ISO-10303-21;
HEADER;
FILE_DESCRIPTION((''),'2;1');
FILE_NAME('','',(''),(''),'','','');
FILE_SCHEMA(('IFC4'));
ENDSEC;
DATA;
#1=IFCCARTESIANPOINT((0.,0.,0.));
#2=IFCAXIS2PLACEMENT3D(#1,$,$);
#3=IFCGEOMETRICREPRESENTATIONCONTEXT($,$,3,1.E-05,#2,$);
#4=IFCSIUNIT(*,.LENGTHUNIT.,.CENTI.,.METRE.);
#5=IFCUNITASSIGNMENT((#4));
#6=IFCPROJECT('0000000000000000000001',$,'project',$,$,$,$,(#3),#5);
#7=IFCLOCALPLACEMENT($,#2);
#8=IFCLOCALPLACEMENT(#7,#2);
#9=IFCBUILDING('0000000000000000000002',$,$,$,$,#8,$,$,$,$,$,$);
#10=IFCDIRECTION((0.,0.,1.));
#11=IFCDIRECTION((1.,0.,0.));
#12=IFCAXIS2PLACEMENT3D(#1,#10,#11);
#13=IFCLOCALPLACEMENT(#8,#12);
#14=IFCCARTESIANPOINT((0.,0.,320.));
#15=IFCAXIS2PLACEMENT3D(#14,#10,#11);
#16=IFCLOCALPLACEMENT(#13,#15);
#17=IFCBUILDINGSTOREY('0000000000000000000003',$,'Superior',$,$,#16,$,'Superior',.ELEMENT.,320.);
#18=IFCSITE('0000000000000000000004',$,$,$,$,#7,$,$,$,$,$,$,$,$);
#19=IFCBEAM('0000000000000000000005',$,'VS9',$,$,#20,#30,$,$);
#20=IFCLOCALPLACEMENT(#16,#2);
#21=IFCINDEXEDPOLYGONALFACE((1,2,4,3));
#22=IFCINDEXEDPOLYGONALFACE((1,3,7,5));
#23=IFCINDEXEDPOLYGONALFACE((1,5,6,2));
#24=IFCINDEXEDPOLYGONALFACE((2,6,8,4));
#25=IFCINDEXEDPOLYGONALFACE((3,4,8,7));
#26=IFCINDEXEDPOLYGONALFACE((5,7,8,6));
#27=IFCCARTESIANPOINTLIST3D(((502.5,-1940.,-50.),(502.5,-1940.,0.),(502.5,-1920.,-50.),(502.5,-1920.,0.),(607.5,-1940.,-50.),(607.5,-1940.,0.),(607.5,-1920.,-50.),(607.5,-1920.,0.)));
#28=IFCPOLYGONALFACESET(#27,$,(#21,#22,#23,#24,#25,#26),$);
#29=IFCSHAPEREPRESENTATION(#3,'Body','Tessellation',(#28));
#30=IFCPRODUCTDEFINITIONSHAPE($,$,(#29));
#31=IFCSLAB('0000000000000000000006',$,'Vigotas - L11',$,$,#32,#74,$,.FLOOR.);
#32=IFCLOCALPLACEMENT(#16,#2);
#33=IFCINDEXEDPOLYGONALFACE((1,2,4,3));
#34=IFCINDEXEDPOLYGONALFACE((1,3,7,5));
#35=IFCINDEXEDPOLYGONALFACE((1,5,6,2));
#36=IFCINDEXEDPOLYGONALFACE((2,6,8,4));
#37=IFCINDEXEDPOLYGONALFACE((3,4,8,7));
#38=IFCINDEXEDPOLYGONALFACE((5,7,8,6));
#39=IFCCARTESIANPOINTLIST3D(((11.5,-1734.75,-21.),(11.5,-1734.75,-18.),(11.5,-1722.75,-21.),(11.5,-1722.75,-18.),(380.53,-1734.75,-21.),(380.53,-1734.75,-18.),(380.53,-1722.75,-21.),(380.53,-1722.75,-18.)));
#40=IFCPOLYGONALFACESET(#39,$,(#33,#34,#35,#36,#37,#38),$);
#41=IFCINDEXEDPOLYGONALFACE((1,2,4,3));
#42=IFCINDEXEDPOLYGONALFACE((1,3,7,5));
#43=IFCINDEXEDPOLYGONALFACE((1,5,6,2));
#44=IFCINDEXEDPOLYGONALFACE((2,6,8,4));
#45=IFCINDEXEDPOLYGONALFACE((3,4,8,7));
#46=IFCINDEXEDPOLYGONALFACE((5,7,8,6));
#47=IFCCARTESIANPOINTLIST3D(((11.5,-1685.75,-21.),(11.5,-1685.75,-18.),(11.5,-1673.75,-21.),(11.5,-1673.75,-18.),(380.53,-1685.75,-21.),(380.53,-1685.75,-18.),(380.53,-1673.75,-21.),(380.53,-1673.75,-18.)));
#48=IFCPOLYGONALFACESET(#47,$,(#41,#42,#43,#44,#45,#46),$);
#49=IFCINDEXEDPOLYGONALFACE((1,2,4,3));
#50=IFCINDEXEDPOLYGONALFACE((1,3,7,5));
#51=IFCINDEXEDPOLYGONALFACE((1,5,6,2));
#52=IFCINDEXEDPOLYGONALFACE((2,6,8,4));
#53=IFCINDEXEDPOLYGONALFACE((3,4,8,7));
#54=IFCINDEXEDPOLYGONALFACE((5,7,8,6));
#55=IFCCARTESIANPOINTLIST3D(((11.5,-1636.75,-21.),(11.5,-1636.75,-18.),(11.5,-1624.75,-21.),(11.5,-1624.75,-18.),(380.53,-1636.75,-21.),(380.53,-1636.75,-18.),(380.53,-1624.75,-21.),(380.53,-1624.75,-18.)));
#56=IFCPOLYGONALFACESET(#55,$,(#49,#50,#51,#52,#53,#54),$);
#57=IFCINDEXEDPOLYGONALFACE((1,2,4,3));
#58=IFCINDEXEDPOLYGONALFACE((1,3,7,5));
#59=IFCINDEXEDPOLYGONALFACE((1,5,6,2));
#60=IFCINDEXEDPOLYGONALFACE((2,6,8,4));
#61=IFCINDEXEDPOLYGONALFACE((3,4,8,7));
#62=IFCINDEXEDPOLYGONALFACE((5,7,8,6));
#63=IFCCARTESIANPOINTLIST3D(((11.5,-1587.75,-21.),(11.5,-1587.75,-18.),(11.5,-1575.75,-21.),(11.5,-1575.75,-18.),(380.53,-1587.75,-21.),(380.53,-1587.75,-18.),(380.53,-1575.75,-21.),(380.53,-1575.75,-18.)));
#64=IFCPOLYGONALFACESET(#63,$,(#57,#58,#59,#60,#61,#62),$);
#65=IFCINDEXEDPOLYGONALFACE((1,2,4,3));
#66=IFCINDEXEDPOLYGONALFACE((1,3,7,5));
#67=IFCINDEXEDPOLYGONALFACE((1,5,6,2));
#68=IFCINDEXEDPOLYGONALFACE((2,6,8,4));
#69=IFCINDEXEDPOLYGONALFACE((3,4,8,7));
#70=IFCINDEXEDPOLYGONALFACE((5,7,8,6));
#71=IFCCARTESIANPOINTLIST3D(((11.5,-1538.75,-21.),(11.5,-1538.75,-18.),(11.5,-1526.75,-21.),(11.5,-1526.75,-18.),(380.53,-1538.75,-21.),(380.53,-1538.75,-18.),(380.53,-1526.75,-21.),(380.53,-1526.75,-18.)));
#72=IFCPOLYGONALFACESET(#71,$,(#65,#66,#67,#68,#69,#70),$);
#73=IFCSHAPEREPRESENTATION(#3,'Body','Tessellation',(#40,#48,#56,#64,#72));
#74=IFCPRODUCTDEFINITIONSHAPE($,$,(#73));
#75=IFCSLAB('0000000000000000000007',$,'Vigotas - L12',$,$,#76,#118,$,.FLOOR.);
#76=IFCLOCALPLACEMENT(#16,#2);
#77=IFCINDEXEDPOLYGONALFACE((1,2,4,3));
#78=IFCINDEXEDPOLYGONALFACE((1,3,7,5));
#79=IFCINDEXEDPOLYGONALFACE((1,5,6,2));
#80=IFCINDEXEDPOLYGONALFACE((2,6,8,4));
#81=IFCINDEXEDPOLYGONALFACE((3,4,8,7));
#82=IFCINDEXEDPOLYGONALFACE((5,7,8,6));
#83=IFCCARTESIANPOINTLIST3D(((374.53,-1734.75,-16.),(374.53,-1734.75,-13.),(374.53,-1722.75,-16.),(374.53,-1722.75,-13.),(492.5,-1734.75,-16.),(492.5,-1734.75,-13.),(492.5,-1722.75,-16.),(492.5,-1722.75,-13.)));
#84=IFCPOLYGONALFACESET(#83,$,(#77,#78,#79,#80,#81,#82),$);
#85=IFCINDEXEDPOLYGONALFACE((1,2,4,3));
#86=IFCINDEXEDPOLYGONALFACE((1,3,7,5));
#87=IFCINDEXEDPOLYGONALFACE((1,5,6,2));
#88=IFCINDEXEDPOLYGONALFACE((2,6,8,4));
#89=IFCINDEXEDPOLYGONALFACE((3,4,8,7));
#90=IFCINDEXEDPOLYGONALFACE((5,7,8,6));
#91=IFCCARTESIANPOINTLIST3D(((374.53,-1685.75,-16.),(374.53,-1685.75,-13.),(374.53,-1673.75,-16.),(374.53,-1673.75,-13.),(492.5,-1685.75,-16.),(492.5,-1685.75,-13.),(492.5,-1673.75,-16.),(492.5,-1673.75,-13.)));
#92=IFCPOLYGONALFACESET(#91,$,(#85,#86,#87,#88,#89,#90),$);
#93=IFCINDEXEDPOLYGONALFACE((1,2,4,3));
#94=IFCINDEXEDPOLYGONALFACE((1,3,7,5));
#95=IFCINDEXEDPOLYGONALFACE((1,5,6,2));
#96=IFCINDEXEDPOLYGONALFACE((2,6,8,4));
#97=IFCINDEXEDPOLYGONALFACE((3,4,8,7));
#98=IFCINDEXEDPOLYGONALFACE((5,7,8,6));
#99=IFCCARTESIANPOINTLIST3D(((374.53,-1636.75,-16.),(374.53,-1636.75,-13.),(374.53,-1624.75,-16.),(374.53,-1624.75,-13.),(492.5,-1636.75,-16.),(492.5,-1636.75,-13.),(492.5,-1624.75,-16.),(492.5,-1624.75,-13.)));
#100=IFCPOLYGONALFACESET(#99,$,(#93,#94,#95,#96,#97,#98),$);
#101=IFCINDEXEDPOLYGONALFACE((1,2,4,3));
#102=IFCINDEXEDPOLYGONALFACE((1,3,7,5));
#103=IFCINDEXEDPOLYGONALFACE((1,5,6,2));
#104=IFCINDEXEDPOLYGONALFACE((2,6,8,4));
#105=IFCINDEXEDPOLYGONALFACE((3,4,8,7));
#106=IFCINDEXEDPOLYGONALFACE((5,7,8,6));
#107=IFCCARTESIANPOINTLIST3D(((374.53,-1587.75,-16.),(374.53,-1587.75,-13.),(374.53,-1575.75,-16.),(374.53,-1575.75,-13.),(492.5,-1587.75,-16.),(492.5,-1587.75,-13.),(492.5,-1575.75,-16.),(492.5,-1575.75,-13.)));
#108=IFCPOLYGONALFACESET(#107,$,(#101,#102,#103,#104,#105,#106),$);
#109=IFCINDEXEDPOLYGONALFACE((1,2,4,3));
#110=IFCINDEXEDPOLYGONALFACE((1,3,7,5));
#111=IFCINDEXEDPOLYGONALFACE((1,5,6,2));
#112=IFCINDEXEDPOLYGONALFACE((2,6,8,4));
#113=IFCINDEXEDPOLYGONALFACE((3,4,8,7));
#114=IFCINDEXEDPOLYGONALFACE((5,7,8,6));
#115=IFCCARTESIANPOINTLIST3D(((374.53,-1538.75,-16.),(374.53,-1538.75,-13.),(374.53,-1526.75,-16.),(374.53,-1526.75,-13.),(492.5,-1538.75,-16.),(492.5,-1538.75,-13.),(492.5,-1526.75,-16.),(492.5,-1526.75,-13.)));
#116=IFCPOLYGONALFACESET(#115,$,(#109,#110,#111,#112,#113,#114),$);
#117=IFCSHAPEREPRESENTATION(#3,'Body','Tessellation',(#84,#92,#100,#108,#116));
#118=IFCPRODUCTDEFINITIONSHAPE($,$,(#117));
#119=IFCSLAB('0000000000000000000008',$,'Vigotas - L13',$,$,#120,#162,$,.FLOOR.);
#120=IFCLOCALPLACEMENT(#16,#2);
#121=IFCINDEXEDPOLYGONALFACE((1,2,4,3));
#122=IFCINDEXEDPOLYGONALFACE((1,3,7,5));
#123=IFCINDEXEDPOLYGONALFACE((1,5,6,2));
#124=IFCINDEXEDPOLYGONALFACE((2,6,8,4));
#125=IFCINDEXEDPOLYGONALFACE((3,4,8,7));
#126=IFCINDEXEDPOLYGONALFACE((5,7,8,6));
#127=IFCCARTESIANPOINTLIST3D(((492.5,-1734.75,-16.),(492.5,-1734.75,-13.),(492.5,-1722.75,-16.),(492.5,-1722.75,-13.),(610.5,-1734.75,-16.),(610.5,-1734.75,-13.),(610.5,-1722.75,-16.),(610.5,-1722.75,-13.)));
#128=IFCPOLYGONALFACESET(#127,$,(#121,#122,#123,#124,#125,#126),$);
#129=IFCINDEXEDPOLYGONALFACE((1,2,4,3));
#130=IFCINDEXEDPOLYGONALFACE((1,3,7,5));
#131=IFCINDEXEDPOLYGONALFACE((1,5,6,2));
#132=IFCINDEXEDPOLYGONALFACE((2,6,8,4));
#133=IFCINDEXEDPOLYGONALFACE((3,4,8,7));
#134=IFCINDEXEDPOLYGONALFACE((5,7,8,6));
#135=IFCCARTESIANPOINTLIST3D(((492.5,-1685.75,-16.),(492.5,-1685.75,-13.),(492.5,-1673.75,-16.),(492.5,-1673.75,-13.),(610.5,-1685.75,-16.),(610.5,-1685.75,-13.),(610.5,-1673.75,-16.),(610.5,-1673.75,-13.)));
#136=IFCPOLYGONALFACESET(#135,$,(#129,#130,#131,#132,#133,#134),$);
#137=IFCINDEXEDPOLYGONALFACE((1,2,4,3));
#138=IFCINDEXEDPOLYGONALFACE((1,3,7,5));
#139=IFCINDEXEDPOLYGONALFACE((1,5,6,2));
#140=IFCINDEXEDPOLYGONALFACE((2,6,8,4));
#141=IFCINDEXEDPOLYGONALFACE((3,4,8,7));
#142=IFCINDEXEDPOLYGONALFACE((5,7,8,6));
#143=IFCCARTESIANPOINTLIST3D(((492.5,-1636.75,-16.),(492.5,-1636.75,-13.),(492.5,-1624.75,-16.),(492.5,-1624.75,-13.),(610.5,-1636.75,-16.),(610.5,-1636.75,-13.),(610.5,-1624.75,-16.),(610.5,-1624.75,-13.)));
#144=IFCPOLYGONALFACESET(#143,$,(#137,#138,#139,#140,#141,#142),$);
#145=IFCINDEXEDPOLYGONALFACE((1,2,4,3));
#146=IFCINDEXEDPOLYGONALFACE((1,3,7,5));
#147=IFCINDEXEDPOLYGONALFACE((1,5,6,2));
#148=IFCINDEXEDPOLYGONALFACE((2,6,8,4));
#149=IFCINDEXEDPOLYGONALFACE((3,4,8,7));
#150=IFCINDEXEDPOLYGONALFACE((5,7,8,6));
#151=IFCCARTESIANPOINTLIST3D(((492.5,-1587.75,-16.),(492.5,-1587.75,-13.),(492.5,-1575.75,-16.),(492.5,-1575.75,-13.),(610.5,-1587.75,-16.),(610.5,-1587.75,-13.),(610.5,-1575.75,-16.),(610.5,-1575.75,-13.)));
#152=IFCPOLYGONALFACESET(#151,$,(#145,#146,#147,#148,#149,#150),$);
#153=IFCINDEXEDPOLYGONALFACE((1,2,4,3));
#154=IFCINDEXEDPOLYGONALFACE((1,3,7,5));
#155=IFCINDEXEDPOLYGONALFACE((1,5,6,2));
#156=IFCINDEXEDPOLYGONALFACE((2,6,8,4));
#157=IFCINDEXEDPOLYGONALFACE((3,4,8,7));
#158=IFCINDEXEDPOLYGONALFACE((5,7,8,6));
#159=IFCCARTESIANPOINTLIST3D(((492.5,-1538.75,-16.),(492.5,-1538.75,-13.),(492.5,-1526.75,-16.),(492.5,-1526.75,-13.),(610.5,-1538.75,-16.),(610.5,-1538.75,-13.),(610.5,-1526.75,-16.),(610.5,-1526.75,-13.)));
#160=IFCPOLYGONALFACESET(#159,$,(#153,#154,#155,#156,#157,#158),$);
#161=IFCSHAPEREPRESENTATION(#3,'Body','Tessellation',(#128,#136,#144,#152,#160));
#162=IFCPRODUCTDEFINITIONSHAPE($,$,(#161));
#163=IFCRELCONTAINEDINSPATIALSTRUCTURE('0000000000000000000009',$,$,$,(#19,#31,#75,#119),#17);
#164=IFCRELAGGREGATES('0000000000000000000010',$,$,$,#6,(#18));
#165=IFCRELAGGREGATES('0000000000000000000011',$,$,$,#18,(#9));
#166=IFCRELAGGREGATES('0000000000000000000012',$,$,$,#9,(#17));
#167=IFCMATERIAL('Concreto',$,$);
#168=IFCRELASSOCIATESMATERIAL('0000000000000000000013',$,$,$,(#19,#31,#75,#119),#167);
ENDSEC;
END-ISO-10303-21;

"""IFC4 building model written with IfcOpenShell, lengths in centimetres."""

from ifc_helpers import new_model, si_unit, frame, origin, origin_with_axes, place, context, project, spatial, polyline, outline, extrude, material, element, save


model = new_model("IFC4")

# Units and contexts
context_of_model = context(None, 3, precision=1e-05, world=origin())
ifc_project = project(units=[si_unit("LENGTHUNIT", "METRE", prefix="CENTI")], contexts=[context_of_model])

# Site, building, storey
site_placement = place(None, origin())
site = spatial("IfcSite", under=ifc_project, at=site_placement)
building_placement = place(site_placement, origin())
building = spatial("IfcBuilding", under=site, at=building_placement)
placement = place(building_placement, origin_with_axes())
storey_placement = place(placement, frame((0.0, 0.0, 320.0), z_axis=(0.0, 0.0, 1.0), x_axis=(1.0, 0.0, 0.0)))
storey = spatial("IfcBuildingStorey", under=building, at=storey_placement, Name="Superior", LongName="Superior", CompositionType="ELEMENT", Elevation=320.0)

# Shared definitions
ifc_material = material(Name="Concreto")

# Beam
beam_1_placement = place(storey_placement, frame((555.0, -1930.0, 0.0), z_axis=(0.0, 0.0, 1.0), x_axis=(1.0, 0.0, 0.0)))
element("IfcBeam", 1, at=beam_1_placement, inside=storey, material=ifc_material, Name="VS9", context=context_of_model, shape_type="SolidModel", body=[
    extrude(outline(polyline([(-10.0, -25.0), (10.0, -25.0), (10.0, 25.0), (-10.0, 25.0), (-10.0, -25.0)])), frame((-52.5, 0.0, -25.0), z_axis=(1.0, 0.0, 0.0), x_axis=(0.0, -1.0, 0.0)), (0.0, 0.0, 1.0), 105.0),
])

# Slabs
slab_1_placement = place(storey_placement, frame((196.01, -1630.75, -18.0), z_axis=(0.0, 0.0, 1.0), x_axis=(1.0, 0.0, 0.0)))
element("IfcSlab", 2, at=slab_1_placement, inside=storey, material=ifc_material, Name="Vigotas - L11", PredefinedType="FLOOR", context=context_of_model, shape_type="SolidModel", body=[
    extrude(outline(polyline([(6.0, 1.5), (-6.0, 1.5), (-6.0, -1.5), (6.0, -1.5), (6.0, 1.5), (6.0, 1.5)])), frame((-184.51, -98.0, -1.5), z_axis=(1.0, 0.0, 0.0), x_axis=(0.0, -1.0, 0.0)), (0.0, 0.0, 1.0), 369.03),
    extrude(outline(polyline([(6.0, 1.5), (-6.0, 1.5), (-6.0, -1.5), (6.0, -1.5), (6.0, 1.5), (6.0, 1.5)])), frame((-184.51, -49.0, -1.5), z_axis=(1.0, 0.0, 0.0), x_axis=(0.0, -1.0, 0.0)), (0.0, 0.0, 1.0), 369.03),
    extrude(outline(polyline([(6.0, 1.5), (-6.0, 1.5), (-6.0, -1.5), (6.0, -1.5), (6.0, 1.5), (6.0, 1.5)])), frame((-184.51, 0.0, -1.5), z_axis=(1.0, 0.0, 0.0), x_axis=(0.0, -1.0, 0.0)), (0.0, 0.0, 1.0), 369.03),
    extrude(outline(polyline([(6.0, 1.5), (-6.0, 1.5), (-6.0, -1.5), (6.0, -1.5), (6.0, 1.5), (6.0, 1.5)])), frame((-184.51, 49.0, -1.5), z_axis=(1.0, 0.0, 0.0), x_axis=(0.0, -1.0, 0.0)), (0.0, 0.0, 1.0), 369.03),
    extrude(outline(polyline([(6.0, 1.5), (-6.0, 1.5), (-6.0, -1.5), (6.0, -1.5), (6.0, 1.5), (6.0, 1.5)])), frame((-184.51, 98.0, -1.5), z_axis=(1.0, 0.0, 0.0), x_axis=(0.0, -1.0, 0.0)), (0.0, 0.0, 1.0), 369.03),
])
slab_2_placement = place(storey_placement, frame((433.51, -1630.75, -13.0), z_axis=(0.0, 0.0, 1.0), x_axis=(1.0, 0.0, 0.0)))
element("IfcSlab", 3, at=slab_2_placement, inside=storey, material=ifc_material, Name="Vigotas - L12", PredefinedType="FLOOR", context=context_of_model, shape_type="SolidModel", body=[
    extrude(outline(polyline([(6.0, 1.5), (-6.0, 1.5), (-6.0, -1.5), (6.0, -1.5), (6.0, 1.5), (6.0, 1.5)])), frame((-58.98, -98.0, -1.5), z_axis=(1.0, 0.0, 0.0), x_axis=(0.0, -1.0, 0.0)), (0.0, 0.0, 1.0), 117.97),
    extrude(outline(polyline([(6.0, 1.5), (-6.0, 1.5), (-6.0, -1.5), (6.0, -1.5), (6.0, 1.5), (6.0, 1.5)])), frame((-58.98, -49.0, -1.5), z_axis=(1.0, 0.0, 0.0), x_axis=(0.0, -1.0, 0.0)), (0.0, 0.0, 1.0), 117.97),
    extrude(outline(polyline([(6.0, 1.5), (-6.0, 1.5), (-6.0, -1.5), (6.0, -1.5), (6.0, 1.5), (6.0, 1.5)])), frame((-58.98, 0.0, -1.5), z_axis=(1.0, 0.0, 0.0), x_axis=(0.0, -1.0, 0.0)), (0.0, 0.0, 1.0), 117.97),
    extrude(outline(polyline([(6.0, 1.5), (-6.0, 1.5), (-6.0, -1.5), (6.0, -1.5), (6.0, 1.5), (6.0, 1.5)])), frame((-58.98, 49.0, -1.5), z_axis=(1.0, 0.0, 0.0), x_axis=(0.0, -1.0, 0.0)), (0.0, 0.0, 1.0), 117.97),
    extrude(outline(polyline([(6.0, 1.5), (-6.0, 1.5), (-6.0, -1.5), (6.0, -1.5), (6.0, 1.5), (6.0, 1.5)])), frame((-58.98, 98.0, -1.5), z_axis=(1.0, 0.0, 0.0), x_axis=(0.0, -1.0, 0.0)), (0.0, 0.0, 1.0), 117.97),
])
slab_3_placement = place(storey_placement, frame((551.5, -1630.75, -13.0), z_axis=(0.0, 0.0, 1.0), x_axis=(1.0, 0.0, 0.0)))
element("IfcSlab", 4, at=slab_3_placement, inside=storey, material=ifc_material, Name="Vigotas - L13", PredefinedType="FLOOR", context=context_of_model, shape_type="SolidModel", body=[
    extrude(outline(polyline([(6.0, 1.5), (-6.0, 1.5), (-6.0, -1.5), (6.0, -1.5), (6.0, 1.5), (6.0, 1.5)])), frame((-59.0, -98.0, -1.5), z_axis=(1.0, 0.0, 0.0), x_axis=(0.0, -1.0, 0.0)), (0.0, 0.0, 1.0), 118.0),
    extrude(outline(polyline([(6.0, 1.5), (-6.0, 1.5), (-6.0, -1.5), (6.0, -1.5), (6.0, 1.5), (6.0, 1.5)])), frame((-59.0, -49.0, -1.5), z_axis=(1.0, 0.0, 0.0), x_axis=(0.0, -1.0, 0.0)), (0.0, 0.0, 1.0), 118.0),
    extrude(outline(polyline([(6.0, 1.5), (-6.0, 1.5), (-6.0, -1.5), (6.0, -1.5), (6.0, 1.5), (6.0, 1.5)])), frame((-59.0, 0.0, -1.5), z_axis=(1.0, 0.0, 0.0), x_axis=(0.0, -1.0, 0.0)), (0.0, 0.0, 1.0), 118.0),
    extrude(outline(polyline([(6.0, 1.5), (-6.0, 1.5), (-6.0, -1.5), (6.0, -1.5), (6.0, 1.5), (6.0, 1.5)])), frame((-59.0, 49.0, -1.5), z_axis=(1.0, 0.0, 0.0), x_axis=(0.0, -1.0, 0.0)), (0.0, 0.0, 1.0), 118.0),
    extrude(outline(polyline([(6.0, 1.5), (-6.0, 1.5), (-6.0, -1.5), (6.0, -1.5), (6.0, 1.5), (6.0, 1.5)])), frame((-59.0, 98.0, -1.5), z_axis=(1.0, 0.0, 0.0), x_axis=(0.0, -1.0, 0.0)), (0.0, 0.0, 1.0), 118.0),
])

save(model, "model.ifc")
